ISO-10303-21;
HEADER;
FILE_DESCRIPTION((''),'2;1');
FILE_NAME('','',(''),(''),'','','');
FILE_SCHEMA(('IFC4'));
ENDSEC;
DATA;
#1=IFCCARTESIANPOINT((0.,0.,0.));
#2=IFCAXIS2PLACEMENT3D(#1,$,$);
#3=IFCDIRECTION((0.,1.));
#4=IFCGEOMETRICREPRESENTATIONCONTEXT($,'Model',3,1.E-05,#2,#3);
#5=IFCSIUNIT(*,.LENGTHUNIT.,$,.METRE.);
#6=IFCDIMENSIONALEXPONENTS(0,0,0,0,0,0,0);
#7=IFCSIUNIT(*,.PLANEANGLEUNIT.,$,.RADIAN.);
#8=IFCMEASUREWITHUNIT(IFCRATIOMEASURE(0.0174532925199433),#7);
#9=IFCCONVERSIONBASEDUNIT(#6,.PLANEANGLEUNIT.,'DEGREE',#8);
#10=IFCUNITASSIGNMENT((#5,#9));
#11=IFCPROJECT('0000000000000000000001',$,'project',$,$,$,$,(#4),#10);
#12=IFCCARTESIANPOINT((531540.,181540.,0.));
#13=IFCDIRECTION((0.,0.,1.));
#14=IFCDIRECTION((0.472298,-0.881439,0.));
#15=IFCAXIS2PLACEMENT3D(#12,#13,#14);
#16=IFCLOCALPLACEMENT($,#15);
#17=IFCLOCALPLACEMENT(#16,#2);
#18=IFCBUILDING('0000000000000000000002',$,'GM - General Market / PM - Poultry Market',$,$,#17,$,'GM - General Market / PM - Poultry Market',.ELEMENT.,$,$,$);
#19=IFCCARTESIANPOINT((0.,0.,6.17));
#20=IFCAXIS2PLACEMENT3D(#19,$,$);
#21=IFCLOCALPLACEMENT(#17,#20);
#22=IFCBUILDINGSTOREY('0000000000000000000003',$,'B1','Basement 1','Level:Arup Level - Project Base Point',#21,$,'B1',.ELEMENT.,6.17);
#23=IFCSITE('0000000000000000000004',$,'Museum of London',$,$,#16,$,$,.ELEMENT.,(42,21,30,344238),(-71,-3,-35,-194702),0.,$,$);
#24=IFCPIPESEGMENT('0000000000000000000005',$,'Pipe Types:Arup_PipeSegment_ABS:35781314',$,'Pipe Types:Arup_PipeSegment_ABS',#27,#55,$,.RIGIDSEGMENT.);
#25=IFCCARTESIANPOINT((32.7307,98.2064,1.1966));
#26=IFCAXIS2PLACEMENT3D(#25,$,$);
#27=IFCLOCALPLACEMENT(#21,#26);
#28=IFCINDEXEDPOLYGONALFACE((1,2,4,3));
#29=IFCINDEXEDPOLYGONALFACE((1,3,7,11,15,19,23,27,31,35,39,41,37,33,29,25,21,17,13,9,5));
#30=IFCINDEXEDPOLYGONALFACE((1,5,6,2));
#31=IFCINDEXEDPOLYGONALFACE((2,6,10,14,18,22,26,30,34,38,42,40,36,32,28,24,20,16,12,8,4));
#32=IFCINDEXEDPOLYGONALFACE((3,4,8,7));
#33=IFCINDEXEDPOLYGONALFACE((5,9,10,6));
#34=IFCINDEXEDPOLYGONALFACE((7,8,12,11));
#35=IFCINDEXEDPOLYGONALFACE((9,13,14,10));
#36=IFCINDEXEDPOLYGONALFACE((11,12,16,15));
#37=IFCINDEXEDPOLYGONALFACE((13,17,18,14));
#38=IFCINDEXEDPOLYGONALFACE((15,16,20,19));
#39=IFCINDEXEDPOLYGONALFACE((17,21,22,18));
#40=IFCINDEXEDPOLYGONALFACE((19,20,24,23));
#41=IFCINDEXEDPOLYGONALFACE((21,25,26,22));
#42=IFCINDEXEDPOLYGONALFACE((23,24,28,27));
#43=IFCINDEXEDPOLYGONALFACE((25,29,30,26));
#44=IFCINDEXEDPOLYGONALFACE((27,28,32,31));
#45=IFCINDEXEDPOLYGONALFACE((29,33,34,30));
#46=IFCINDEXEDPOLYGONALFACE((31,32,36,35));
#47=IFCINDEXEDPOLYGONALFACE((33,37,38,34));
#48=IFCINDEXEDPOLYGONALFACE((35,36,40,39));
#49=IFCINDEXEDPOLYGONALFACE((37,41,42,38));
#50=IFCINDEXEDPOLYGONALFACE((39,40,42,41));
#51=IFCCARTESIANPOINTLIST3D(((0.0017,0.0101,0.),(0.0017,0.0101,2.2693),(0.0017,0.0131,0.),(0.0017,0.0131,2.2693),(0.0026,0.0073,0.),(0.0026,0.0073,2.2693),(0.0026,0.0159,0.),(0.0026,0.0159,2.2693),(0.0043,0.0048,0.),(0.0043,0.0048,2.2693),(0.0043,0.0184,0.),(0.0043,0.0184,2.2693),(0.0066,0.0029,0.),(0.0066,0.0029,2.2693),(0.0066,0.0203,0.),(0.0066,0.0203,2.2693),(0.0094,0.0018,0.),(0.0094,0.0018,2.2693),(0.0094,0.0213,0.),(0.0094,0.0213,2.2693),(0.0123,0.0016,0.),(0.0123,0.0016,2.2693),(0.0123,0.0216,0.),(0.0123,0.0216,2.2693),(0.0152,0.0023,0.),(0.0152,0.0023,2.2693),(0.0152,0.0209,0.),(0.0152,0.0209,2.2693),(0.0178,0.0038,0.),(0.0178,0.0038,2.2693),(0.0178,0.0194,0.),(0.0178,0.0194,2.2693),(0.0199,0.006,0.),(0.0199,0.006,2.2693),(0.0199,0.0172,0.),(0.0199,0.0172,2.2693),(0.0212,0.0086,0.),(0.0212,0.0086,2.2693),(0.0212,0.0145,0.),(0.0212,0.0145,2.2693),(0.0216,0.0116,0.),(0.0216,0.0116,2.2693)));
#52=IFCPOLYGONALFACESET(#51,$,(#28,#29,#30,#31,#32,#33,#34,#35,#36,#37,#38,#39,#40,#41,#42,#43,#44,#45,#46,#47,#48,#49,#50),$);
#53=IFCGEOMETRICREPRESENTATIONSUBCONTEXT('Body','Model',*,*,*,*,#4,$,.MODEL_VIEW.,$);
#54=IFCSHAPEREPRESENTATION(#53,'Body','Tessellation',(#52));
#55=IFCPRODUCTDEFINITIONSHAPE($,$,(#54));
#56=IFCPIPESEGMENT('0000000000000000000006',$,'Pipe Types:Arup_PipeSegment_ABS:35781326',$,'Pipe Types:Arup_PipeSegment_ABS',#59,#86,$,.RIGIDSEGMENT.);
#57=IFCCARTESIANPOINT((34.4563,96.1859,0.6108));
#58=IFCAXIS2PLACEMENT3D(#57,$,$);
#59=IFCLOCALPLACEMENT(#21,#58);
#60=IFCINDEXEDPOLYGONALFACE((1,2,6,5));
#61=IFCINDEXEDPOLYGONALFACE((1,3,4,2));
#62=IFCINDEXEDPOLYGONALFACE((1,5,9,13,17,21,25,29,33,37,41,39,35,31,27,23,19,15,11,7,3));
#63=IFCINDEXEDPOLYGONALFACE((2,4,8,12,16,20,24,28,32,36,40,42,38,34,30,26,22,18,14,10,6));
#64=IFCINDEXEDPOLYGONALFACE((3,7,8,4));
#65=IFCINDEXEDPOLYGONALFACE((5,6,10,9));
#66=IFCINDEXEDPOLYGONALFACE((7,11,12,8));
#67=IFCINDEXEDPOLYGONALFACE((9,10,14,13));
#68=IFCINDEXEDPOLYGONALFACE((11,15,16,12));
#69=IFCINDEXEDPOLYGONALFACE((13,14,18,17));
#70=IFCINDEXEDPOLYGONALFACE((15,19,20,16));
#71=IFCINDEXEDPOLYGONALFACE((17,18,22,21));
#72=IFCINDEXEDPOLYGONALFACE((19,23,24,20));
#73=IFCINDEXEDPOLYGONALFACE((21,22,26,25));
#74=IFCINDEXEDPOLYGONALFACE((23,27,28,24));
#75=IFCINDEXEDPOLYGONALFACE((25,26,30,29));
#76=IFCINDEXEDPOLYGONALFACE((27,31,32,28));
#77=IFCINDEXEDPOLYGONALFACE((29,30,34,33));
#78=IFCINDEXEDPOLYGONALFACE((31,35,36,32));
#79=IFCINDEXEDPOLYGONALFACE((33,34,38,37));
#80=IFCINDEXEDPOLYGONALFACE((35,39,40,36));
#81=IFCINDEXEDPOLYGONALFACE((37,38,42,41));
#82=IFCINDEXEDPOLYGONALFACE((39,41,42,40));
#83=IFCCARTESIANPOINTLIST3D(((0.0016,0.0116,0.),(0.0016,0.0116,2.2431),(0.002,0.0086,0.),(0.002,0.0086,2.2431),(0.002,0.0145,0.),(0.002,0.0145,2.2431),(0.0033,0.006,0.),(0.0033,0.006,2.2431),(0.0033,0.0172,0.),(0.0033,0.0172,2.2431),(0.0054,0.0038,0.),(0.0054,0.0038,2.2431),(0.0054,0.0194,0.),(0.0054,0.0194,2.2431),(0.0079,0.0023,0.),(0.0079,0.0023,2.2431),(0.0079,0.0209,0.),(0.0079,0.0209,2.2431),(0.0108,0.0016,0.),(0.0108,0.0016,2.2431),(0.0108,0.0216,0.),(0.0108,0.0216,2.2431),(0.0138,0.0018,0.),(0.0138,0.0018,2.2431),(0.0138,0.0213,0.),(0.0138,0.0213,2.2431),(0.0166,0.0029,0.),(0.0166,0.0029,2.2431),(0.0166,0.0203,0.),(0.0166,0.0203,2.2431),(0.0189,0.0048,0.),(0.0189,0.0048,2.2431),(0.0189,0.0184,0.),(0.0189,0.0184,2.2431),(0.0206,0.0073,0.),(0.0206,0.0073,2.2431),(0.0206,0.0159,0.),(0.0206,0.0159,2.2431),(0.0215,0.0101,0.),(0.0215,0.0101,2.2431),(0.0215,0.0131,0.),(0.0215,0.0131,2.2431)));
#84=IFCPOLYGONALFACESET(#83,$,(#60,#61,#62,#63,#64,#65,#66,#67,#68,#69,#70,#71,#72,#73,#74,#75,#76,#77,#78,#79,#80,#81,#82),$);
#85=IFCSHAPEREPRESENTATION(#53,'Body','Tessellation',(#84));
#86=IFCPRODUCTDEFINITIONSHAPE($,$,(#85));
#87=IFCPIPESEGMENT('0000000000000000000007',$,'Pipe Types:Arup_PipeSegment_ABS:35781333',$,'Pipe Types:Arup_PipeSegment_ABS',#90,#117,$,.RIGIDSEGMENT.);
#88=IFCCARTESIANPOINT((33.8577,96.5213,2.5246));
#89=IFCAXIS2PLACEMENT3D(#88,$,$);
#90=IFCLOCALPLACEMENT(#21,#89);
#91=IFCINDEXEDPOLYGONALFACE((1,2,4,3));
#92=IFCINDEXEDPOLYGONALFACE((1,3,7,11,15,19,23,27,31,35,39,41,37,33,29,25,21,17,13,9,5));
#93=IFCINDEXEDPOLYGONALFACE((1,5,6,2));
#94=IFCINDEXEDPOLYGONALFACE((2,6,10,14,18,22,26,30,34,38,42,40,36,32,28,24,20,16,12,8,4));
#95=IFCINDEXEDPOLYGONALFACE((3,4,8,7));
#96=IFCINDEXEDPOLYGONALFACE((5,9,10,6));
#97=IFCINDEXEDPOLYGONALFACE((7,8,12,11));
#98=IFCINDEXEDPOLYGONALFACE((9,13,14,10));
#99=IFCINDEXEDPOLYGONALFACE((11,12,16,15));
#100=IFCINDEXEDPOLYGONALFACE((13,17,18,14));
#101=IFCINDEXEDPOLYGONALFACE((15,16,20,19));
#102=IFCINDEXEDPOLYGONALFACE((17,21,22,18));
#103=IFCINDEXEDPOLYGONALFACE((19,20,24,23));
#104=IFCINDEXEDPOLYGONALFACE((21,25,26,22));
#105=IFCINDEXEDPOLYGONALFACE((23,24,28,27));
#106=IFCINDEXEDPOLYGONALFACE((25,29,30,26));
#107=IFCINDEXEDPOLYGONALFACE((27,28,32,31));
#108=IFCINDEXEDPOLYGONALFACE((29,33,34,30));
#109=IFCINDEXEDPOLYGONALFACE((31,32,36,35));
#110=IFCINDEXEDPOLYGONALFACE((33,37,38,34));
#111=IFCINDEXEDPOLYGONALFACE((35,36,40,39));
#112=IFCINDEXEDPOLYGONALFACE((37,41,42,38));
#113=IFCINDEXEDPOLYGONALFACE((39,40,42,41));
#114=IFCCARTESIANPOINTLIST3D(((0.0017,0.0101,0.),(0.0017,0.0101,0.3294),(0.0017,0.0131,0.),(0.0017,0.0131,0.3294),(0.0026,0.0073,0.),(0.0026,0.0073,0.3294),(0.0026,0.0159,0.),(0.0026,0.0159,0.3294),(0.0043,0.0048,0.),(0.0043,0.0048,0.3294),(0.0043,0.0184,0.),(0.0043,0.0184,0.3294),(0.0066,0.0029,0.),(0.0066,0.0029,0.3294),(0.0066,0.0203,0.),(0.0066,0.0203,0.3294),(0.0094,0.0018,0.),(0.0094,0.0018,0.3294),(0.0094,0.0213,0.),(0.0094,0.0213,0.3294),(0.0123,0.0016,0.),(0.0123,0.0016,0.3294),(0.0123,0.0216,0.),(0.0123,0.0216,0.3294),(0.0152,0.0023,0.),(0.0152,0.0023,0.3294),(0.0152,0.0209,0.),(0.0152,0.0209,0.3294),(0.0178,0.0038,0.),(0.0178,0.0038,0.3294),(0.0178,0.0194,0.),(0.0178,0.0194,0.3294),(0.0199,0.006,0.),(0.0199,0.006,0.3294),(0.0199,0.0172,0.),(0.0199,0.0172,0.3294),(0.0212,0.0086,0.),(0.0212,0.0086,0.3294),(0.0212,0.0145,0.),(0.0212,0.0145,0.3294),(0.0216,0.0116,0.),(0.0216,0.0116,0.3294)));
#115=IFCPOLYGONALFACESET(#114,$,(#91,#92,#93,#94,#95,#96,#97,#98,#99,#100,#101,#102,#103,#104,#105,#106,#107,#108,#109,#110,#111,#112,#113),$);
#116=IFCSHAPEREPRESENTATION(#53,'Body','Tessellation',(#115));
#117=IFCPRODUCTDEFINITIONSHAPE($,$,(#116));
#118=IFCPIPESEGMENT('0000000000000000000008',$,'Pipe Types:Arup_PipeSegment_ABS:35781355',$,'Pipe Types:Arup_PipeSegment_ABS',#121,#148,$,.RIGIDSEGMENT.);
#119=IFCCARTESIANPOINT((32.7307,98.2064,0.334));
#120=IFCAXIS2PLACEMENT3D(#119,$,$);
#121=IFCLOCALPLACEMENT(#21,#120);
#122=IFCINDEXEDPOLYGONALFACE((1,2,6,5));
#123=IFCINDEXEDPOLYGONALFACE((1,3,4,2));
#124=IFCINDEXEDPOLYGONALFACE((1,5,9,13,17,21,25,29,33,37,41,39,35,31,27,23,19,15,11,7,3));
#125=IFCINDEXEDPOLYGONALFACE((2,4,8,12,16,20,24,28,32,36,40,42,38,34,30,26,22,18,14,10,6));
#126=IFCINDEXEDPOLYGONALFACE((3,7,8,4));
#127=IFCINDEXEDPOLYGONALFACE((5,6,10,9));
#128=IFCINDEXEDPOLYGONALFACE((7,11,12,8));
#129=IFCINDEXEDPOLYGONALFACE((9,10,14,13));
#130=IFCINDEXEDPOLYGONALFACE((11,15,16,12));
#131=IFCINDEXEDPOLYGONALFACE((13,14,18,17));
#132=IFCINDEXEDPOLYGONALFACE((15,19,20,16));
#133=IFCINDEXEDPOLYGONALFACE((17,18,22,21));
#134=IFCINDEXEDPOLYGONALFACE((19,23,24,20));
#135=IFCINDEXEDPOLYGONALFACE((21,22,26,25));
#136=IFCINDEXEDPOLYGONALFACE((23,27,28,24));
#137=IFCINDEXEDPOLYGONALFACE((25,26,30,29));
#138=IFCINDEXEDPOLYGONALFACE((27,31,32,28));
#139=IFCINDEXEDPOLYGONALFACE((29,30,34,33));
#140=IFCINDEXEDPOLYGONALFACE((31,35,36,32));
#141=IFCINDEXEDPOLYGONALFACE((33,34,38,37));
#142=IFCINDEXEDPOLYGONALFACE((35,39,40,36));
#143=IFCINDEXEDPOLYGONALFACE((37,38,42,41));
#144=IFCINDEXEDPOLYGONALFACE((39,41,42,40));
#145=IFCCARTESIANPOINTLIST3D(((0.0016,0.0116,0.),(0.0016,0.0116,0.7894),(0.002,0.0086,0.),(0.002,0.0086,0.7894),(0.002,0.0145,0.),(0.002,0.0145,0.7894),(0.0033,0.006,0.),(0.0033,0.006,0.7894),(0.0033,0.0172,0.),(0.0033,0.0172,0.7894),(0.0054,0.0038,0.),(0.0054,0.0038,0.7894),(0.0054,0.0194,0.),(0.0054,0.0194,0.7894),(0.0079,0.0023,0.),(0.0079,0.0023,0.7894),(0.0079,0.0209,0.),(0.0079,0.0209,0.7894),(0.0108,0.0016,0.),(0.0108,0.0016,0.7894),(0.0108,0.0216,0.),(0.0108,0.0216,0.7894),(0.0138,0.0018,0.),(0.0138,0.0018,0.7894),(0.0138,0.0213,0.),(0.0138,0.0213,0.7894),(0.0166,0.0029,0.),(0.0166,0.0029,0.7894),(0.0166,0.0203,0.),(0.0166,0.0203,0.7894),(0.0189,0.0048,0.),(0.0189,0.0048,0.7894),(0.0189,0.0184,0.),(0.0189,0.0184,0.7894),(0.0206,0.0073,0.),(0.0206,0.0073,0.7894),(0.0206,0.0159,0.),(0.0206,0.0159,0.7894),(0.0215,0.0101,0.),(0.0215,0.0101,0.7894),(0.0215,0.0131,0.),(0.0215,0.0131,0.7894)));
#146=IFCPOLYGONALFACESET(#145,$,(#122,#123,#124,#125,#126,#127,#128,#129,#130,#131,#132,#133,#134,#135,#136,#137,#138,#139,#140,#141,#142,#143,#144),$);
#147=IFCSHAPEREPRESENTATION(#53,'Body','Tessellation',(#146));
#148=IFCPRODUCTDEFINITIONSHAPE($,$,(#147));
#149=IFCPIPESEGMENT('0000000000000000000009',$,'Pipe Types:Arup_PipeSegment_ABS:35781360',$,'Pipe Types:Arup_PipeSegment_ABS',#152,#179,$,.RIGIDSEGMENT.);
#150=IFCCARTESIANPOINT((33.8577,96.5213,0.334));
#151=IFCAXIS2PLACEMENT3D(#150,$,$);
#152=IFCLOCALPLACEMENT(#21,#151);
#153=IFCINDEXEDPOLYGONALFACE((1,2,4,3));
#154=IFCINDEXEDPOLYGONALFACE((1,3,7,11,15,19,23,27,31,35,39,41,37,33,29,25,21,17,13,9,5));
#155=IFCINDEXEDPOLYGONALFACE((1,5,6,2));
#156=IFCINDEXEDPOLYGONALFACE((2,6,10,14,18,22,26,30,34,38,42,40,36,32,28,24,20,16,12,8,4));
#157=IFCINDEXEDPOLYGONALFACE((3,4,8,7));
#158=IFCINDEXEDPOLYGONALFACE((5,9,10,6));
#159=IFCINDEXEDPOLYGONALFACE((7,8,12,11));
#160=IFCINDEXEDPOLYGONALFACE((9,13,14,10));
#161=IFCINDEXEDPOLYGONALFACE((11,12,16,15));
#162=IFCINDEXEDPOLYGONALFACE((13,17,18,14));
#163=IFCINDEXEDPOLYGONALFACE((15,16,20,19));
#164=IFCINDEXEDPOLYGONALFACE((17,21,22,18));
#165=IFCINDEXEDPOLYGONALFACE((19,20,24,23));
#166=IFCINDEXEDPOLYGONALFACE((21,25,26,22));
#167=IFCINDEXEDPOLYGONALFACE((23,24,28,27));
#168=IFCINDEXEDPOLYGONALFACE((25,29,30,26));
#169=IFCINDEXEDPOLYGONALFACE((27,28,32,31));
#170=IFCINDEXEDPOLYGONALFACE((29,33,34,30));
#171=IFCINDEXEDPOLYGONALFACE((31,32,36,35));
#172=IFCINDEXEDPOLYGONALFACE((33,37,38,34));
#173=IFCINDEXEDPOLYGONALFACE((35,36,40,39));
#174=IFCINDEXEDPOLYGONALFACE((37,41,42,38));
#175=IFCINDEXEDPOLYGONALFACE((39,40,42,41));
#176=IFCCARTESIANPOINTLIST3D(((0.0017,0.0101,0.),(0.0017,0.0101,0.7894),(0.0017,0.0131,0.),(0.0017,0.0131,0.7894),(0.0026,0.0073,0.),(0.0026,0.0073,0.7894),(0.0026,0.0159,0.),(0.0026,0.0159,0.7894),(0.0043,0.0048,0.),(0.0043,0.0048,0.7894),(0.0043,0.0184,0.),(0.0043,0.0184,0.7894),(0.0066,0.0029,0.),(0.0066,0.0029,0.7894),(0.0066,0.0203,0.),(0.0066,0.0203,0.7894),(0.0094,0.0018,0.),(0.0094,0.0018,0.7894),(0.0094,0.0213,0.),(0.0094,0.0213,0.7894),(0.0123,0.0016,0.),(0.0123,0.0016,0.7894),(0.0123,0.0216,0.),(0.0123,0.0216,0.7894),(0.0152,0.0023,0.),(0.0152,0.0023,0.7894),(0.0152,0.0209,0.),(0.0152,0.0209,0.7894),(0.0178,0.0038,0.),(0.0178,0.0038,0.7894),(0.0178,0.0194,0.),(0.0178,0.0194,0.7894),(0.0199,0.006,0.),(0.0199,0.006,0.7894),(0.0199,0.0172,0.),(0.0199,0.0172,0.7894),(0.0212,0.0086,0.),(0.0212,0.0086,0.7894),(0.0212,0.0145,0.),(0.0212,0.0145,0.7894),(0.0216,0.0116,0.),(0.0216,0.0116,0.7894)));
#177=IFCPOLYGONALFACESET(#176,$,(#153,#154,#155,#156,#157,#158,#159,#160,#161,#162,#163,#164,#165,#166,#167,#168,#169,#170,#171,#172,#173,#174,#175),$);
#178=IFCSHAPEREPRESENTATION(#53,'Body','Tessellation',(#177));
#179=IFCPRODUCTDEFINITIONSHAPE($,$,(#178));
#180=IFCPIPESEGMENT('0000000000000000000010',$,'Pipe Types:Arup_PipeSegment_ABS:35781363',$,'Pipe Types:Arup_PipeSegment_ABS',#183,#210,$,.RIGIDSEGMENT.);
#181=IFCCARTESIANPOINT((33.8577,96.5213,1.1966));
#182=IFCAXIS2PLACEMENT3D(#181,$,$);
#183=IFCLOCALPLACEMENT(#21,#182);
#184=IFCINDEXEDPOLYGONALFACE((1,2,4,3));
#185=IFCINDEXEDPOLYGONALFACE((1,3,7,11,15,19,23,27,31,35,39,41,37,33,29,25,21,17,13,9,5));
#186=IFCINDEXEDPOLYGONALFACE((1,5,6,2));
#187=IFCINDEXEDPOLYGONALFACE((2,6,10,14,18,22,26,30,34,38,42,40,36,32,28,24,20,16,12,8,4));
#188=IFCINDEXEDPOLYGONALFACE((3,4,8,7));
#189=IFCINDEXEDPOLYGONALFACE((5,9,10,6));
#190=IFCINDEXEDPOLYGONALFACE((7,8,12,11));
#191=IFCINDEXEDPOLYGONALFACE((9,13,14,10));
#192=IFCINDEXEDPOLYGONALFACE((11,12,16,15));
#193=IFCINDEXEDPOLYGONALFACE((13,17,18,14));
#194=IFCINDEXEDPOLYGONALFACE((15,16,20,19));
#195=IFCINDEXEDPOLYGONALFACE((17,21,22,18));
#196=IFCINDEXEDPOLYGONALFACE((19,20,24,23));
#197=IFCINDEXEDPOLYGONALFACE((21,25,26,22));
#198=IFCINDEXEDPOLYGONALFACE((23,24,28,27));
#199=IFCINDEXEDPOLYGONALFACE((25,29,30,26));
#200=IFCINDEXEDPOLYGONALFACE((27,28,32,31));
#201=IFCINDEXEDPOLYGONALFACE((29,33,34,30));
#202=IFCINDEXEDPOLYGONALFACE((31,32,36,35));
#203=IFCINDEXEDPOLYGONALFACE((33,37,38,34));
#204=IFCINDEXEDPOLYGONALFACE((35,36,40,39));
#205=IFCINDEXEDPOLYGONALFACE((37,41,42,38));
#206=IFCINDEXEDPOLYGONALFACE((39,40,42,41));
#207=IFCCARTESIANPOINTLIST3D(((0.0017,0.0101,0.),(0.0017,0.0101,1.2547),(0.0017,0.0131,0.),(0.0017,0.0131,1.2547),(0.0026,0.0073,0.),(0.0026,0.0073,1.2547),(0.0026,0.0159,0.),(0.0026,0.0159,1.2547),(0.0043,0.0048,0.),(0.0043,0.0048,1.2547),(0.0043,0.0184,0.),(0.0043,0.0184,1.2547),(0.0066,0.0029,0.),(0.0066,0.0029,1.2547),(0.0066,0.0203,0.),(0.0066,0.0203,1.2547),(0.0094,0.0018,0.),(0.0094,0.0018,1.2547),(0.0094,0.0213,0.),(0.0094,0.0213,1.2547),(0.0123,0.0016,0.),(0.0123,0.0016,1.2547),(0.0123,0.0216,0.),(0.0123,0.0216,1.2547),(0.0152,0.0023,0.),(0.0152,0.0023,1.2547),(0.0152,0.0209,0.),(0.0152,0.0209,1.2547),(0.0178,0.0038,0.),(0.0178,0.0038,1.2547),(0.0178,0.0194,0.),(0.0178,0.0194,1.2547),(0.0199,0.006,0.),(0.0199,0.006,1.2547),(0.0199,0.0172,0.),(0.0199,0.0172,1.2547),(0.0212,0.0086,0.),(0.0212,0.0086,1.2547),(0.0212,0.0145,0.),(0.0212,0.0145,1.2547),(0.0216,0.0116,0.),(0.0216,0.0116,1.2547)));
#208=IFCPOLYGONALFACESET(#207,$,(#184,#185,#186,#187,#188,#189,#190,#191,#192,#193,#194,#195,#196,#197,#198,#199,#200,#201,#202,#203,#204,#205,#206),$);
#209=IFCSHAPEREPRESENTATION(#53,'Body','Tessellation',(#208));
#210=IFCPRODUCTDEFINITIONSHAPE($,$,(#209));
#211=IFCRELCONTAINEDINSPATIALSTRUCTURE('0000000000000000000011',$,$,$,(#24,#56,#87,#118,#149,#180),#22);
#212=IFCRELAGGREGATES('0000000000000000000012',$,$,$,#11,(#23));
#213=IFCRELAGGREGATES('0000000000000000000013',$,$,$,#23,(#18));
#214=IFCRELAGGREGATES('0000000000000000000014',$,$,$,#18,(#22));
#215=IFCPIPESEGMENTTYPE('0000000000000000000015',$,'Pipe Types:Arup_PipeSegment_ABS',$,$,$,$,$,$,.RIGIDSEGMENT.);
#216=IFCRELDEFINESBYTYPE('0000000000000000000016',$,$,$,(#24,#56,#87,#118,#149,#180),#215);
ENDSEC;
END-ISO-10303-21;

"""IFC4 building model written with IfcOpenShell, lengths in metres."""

from ifc_helpers import new_model, entity, si_unit, converted_unit, direction, frame, origin, origin_2d_with_axis, place, context, subcontext, project, spatial, circle, extrude, type_object, element, save


model = new_model("IFC4")

# Units and contexts
model_context = context("Model", 3, precision=1e-05, world=origin(), true_north=direction((0.0, 1.0)))
body_context = subcontext(model_context, "Body", "Model", "MODEL_VIEW")
ifc_project = project(units=[si_unit("LENGTHUNIT", "METRE"), converted_unit("PLANEANGLEUNIT", "DEGREE", entity("IfcRatioMeasure", 0.0174532925199433), si_unit("PLANEANGLEUNIT", "RADIAN"), dimensions=[0, 0, 0, 0, 0, 0, 0])], contexts=[model_context])

# Site, building, storey
site_placement = place(None, frame((531540.0, 181540.0, 0.0), z_axis=(0.0, 0.0, 1.0), x_axis=(0.472298, -0.881439, 0.0)))
site = spatial("IfcSite", under=ifc_project, at=site_placement, Name="Museum of London", CompositionType="ELEMENT", RefLatitude=(42, 21, 30, 344238), RefLongitude=(-71, -3, -35, -194702), RefElevation=0.0)
building_placement = place(site_placement, origin())
building = spatial("IfcBuilding", under=site, at=building_placement, Name="GM - General Market / PM - Poultry Market", LongName="GM - General Market / PM - Poultry Market", CompositionType="ELEMENT")
storey_placement = place(building_placement, frame((0.0, 0.0, 6.17)))
storey = spatial("IfcBuildingStorey", under=building, at=storey_placement, Name="B1", Description="Basement 1", ObjectType="Level:Arup Level - Project Base Point", LongName="B1", CompositionType="ELEMENT", Elevation=6.17)

# Pipe segments
pipe_segment_type_1 = type_object("IfcPipeSegmentType", Name="Pipe Types:Arup_PipeSegment_ABS", PredefinedType="RIGIDSEGMENT")
pipe_segment_1_placement = place(storey_placement, frame((32.7307, 98.2064, 1.1966)))
element("IfcPipeSegment", 1, at=pipe_segment_1_placement, inside=storey, type_object=pipe_segment_type_1, Name="Pipe Types:Arup_PipeSegment_ABS:35781314", ObjectType="Pipe Types:Arup_PipeSegment_ABS", PredefinedType="RIGIDSEGMENT", context=body_context, shape_type="SweptSolid", body=[
    extrude(circle(Radius=0.01, at=origin_2d_with_axis()), frame((0.0116, 0.0116, 0.0)), (0.0, 0.0, 1.0), 2.2694),
])
pipe_segment_2_placement = place(storey_placement, frame((34.4563, 96.1859, 0.6108)))
element("IfcPipeSegment", 2, at=pipe_segment_2_placement, inside=storey, type_object=pipe_segment_type_1, Name="Pipe Types:Arup_PipeSegment_ABS:35781326", ObjectType="Pipe Types:Arup_PipeSegment_ABS", PredefinedType="RIGIDSEGMENT", context=body_context, shape_type="SweptSolid", body=[
    extrude(circle(Radius=0.01, at=origin_2d_with_axis()), frame((0.0116, 0.0116, 0.0), z_axis=(0.0, 0.0, 1.0), x_axis=(-1.0, 0.0, 0.0)), (0.0, 0.0, 1.0), 2.2431),
])
pipe_segment_3_placement = place(storey_placement, frame((33.8577, 96.5213, 2.5246)))
element("IfcPipeSegment", 3, at=pipe_segment_3_placement, inside=storey, type_object=pipe_segment_type_1, Name="Pipe Types:Arup_PipeSegment_ABS:35781333", ObjectType="Pipe Types:Arup_PipeSegment_ABS", PredefinedType="RIGIDSEGMENT", context=body_context, shape_type="SweptSolid", body=[
    extrude(circle(Radius=0.01, at=origin_2d_with_axis()), frame((0.0116, 0.0116, 0.0)), (0.0, 0.0, 1.0), 0.3294),
])
pipe_segment_4_placement = place(storey_placement, frame((32.7307, 98.2064, 0.334)))
element("IfcPipeSegment", 4, at=pipe_segment_4_placement, inside=storey, type_object=pipe_segment_type_1, Name="Pipe Types:Arup_PipeSegment_ABS:35781355", ObjectType="Pipe Types:Arup_PipeSegment_ABS", PredefinedType="RIGIDSEGMENT", context=body_context, shape_type="SweptSolid", body=[
    extrude(circle(Radius=0.01, at=origin_2d_with_axis()), frame((0.0116, 0.0116, 0.0), z_axis=(0.0, 0.0, 1.0), x_axis=(-1.0, 0.0, 0.0)), (0.0, 0.0, 1.0), 0.7894),
])
pipe_segment_5_placement = place(storey_placement, frame((33.8577, 96.5213, 0.334)))
element("IfcPipeSegment", 5, at=pipe_segment_5_placement, inside=storey, type_object=pipe_segment_type_1, Name="Pipe Types:Arup_PipeSegment_ABS:35781360", ObjectType="Pipe Types:Arup_PipeSegment_ABS", PredefinedType="RIGIDSEGMENT", context=body_context, shape_type="SweptSolid", body=[
    extrude(circle(Radius=0.01, at=origin_2d_with_axis()), frame((0.0116, 0.0116, 0.0)), (0.0, 0.0, 1.0), 0.7894),
])
pipe_segment_6_placement = place(storey_placement, frame((33.8577, 96.5213, 1.1966)))
element("IfcPipeSegment", 6, at=pipe_segment_6_placement, inside=storey, type_object=pipe_segment_type_1, Name="Pipe Types:Arup_PipeSegment_ABS:35781363", ObjectType="Pipe Types:Arup_PipeSegment_ABS", PredefinedType="RIGIDSEGMENT", context=body_context, shape_type="SweptSolid", body=[
    extrude(circle(Radius=0.01, at=origin_2d_with_axis()), frame((0.0116, 0.0116, 0.0)), (0.0, 0.0, 1.0), 1.2547),
])

save(model, "model.ifc")
